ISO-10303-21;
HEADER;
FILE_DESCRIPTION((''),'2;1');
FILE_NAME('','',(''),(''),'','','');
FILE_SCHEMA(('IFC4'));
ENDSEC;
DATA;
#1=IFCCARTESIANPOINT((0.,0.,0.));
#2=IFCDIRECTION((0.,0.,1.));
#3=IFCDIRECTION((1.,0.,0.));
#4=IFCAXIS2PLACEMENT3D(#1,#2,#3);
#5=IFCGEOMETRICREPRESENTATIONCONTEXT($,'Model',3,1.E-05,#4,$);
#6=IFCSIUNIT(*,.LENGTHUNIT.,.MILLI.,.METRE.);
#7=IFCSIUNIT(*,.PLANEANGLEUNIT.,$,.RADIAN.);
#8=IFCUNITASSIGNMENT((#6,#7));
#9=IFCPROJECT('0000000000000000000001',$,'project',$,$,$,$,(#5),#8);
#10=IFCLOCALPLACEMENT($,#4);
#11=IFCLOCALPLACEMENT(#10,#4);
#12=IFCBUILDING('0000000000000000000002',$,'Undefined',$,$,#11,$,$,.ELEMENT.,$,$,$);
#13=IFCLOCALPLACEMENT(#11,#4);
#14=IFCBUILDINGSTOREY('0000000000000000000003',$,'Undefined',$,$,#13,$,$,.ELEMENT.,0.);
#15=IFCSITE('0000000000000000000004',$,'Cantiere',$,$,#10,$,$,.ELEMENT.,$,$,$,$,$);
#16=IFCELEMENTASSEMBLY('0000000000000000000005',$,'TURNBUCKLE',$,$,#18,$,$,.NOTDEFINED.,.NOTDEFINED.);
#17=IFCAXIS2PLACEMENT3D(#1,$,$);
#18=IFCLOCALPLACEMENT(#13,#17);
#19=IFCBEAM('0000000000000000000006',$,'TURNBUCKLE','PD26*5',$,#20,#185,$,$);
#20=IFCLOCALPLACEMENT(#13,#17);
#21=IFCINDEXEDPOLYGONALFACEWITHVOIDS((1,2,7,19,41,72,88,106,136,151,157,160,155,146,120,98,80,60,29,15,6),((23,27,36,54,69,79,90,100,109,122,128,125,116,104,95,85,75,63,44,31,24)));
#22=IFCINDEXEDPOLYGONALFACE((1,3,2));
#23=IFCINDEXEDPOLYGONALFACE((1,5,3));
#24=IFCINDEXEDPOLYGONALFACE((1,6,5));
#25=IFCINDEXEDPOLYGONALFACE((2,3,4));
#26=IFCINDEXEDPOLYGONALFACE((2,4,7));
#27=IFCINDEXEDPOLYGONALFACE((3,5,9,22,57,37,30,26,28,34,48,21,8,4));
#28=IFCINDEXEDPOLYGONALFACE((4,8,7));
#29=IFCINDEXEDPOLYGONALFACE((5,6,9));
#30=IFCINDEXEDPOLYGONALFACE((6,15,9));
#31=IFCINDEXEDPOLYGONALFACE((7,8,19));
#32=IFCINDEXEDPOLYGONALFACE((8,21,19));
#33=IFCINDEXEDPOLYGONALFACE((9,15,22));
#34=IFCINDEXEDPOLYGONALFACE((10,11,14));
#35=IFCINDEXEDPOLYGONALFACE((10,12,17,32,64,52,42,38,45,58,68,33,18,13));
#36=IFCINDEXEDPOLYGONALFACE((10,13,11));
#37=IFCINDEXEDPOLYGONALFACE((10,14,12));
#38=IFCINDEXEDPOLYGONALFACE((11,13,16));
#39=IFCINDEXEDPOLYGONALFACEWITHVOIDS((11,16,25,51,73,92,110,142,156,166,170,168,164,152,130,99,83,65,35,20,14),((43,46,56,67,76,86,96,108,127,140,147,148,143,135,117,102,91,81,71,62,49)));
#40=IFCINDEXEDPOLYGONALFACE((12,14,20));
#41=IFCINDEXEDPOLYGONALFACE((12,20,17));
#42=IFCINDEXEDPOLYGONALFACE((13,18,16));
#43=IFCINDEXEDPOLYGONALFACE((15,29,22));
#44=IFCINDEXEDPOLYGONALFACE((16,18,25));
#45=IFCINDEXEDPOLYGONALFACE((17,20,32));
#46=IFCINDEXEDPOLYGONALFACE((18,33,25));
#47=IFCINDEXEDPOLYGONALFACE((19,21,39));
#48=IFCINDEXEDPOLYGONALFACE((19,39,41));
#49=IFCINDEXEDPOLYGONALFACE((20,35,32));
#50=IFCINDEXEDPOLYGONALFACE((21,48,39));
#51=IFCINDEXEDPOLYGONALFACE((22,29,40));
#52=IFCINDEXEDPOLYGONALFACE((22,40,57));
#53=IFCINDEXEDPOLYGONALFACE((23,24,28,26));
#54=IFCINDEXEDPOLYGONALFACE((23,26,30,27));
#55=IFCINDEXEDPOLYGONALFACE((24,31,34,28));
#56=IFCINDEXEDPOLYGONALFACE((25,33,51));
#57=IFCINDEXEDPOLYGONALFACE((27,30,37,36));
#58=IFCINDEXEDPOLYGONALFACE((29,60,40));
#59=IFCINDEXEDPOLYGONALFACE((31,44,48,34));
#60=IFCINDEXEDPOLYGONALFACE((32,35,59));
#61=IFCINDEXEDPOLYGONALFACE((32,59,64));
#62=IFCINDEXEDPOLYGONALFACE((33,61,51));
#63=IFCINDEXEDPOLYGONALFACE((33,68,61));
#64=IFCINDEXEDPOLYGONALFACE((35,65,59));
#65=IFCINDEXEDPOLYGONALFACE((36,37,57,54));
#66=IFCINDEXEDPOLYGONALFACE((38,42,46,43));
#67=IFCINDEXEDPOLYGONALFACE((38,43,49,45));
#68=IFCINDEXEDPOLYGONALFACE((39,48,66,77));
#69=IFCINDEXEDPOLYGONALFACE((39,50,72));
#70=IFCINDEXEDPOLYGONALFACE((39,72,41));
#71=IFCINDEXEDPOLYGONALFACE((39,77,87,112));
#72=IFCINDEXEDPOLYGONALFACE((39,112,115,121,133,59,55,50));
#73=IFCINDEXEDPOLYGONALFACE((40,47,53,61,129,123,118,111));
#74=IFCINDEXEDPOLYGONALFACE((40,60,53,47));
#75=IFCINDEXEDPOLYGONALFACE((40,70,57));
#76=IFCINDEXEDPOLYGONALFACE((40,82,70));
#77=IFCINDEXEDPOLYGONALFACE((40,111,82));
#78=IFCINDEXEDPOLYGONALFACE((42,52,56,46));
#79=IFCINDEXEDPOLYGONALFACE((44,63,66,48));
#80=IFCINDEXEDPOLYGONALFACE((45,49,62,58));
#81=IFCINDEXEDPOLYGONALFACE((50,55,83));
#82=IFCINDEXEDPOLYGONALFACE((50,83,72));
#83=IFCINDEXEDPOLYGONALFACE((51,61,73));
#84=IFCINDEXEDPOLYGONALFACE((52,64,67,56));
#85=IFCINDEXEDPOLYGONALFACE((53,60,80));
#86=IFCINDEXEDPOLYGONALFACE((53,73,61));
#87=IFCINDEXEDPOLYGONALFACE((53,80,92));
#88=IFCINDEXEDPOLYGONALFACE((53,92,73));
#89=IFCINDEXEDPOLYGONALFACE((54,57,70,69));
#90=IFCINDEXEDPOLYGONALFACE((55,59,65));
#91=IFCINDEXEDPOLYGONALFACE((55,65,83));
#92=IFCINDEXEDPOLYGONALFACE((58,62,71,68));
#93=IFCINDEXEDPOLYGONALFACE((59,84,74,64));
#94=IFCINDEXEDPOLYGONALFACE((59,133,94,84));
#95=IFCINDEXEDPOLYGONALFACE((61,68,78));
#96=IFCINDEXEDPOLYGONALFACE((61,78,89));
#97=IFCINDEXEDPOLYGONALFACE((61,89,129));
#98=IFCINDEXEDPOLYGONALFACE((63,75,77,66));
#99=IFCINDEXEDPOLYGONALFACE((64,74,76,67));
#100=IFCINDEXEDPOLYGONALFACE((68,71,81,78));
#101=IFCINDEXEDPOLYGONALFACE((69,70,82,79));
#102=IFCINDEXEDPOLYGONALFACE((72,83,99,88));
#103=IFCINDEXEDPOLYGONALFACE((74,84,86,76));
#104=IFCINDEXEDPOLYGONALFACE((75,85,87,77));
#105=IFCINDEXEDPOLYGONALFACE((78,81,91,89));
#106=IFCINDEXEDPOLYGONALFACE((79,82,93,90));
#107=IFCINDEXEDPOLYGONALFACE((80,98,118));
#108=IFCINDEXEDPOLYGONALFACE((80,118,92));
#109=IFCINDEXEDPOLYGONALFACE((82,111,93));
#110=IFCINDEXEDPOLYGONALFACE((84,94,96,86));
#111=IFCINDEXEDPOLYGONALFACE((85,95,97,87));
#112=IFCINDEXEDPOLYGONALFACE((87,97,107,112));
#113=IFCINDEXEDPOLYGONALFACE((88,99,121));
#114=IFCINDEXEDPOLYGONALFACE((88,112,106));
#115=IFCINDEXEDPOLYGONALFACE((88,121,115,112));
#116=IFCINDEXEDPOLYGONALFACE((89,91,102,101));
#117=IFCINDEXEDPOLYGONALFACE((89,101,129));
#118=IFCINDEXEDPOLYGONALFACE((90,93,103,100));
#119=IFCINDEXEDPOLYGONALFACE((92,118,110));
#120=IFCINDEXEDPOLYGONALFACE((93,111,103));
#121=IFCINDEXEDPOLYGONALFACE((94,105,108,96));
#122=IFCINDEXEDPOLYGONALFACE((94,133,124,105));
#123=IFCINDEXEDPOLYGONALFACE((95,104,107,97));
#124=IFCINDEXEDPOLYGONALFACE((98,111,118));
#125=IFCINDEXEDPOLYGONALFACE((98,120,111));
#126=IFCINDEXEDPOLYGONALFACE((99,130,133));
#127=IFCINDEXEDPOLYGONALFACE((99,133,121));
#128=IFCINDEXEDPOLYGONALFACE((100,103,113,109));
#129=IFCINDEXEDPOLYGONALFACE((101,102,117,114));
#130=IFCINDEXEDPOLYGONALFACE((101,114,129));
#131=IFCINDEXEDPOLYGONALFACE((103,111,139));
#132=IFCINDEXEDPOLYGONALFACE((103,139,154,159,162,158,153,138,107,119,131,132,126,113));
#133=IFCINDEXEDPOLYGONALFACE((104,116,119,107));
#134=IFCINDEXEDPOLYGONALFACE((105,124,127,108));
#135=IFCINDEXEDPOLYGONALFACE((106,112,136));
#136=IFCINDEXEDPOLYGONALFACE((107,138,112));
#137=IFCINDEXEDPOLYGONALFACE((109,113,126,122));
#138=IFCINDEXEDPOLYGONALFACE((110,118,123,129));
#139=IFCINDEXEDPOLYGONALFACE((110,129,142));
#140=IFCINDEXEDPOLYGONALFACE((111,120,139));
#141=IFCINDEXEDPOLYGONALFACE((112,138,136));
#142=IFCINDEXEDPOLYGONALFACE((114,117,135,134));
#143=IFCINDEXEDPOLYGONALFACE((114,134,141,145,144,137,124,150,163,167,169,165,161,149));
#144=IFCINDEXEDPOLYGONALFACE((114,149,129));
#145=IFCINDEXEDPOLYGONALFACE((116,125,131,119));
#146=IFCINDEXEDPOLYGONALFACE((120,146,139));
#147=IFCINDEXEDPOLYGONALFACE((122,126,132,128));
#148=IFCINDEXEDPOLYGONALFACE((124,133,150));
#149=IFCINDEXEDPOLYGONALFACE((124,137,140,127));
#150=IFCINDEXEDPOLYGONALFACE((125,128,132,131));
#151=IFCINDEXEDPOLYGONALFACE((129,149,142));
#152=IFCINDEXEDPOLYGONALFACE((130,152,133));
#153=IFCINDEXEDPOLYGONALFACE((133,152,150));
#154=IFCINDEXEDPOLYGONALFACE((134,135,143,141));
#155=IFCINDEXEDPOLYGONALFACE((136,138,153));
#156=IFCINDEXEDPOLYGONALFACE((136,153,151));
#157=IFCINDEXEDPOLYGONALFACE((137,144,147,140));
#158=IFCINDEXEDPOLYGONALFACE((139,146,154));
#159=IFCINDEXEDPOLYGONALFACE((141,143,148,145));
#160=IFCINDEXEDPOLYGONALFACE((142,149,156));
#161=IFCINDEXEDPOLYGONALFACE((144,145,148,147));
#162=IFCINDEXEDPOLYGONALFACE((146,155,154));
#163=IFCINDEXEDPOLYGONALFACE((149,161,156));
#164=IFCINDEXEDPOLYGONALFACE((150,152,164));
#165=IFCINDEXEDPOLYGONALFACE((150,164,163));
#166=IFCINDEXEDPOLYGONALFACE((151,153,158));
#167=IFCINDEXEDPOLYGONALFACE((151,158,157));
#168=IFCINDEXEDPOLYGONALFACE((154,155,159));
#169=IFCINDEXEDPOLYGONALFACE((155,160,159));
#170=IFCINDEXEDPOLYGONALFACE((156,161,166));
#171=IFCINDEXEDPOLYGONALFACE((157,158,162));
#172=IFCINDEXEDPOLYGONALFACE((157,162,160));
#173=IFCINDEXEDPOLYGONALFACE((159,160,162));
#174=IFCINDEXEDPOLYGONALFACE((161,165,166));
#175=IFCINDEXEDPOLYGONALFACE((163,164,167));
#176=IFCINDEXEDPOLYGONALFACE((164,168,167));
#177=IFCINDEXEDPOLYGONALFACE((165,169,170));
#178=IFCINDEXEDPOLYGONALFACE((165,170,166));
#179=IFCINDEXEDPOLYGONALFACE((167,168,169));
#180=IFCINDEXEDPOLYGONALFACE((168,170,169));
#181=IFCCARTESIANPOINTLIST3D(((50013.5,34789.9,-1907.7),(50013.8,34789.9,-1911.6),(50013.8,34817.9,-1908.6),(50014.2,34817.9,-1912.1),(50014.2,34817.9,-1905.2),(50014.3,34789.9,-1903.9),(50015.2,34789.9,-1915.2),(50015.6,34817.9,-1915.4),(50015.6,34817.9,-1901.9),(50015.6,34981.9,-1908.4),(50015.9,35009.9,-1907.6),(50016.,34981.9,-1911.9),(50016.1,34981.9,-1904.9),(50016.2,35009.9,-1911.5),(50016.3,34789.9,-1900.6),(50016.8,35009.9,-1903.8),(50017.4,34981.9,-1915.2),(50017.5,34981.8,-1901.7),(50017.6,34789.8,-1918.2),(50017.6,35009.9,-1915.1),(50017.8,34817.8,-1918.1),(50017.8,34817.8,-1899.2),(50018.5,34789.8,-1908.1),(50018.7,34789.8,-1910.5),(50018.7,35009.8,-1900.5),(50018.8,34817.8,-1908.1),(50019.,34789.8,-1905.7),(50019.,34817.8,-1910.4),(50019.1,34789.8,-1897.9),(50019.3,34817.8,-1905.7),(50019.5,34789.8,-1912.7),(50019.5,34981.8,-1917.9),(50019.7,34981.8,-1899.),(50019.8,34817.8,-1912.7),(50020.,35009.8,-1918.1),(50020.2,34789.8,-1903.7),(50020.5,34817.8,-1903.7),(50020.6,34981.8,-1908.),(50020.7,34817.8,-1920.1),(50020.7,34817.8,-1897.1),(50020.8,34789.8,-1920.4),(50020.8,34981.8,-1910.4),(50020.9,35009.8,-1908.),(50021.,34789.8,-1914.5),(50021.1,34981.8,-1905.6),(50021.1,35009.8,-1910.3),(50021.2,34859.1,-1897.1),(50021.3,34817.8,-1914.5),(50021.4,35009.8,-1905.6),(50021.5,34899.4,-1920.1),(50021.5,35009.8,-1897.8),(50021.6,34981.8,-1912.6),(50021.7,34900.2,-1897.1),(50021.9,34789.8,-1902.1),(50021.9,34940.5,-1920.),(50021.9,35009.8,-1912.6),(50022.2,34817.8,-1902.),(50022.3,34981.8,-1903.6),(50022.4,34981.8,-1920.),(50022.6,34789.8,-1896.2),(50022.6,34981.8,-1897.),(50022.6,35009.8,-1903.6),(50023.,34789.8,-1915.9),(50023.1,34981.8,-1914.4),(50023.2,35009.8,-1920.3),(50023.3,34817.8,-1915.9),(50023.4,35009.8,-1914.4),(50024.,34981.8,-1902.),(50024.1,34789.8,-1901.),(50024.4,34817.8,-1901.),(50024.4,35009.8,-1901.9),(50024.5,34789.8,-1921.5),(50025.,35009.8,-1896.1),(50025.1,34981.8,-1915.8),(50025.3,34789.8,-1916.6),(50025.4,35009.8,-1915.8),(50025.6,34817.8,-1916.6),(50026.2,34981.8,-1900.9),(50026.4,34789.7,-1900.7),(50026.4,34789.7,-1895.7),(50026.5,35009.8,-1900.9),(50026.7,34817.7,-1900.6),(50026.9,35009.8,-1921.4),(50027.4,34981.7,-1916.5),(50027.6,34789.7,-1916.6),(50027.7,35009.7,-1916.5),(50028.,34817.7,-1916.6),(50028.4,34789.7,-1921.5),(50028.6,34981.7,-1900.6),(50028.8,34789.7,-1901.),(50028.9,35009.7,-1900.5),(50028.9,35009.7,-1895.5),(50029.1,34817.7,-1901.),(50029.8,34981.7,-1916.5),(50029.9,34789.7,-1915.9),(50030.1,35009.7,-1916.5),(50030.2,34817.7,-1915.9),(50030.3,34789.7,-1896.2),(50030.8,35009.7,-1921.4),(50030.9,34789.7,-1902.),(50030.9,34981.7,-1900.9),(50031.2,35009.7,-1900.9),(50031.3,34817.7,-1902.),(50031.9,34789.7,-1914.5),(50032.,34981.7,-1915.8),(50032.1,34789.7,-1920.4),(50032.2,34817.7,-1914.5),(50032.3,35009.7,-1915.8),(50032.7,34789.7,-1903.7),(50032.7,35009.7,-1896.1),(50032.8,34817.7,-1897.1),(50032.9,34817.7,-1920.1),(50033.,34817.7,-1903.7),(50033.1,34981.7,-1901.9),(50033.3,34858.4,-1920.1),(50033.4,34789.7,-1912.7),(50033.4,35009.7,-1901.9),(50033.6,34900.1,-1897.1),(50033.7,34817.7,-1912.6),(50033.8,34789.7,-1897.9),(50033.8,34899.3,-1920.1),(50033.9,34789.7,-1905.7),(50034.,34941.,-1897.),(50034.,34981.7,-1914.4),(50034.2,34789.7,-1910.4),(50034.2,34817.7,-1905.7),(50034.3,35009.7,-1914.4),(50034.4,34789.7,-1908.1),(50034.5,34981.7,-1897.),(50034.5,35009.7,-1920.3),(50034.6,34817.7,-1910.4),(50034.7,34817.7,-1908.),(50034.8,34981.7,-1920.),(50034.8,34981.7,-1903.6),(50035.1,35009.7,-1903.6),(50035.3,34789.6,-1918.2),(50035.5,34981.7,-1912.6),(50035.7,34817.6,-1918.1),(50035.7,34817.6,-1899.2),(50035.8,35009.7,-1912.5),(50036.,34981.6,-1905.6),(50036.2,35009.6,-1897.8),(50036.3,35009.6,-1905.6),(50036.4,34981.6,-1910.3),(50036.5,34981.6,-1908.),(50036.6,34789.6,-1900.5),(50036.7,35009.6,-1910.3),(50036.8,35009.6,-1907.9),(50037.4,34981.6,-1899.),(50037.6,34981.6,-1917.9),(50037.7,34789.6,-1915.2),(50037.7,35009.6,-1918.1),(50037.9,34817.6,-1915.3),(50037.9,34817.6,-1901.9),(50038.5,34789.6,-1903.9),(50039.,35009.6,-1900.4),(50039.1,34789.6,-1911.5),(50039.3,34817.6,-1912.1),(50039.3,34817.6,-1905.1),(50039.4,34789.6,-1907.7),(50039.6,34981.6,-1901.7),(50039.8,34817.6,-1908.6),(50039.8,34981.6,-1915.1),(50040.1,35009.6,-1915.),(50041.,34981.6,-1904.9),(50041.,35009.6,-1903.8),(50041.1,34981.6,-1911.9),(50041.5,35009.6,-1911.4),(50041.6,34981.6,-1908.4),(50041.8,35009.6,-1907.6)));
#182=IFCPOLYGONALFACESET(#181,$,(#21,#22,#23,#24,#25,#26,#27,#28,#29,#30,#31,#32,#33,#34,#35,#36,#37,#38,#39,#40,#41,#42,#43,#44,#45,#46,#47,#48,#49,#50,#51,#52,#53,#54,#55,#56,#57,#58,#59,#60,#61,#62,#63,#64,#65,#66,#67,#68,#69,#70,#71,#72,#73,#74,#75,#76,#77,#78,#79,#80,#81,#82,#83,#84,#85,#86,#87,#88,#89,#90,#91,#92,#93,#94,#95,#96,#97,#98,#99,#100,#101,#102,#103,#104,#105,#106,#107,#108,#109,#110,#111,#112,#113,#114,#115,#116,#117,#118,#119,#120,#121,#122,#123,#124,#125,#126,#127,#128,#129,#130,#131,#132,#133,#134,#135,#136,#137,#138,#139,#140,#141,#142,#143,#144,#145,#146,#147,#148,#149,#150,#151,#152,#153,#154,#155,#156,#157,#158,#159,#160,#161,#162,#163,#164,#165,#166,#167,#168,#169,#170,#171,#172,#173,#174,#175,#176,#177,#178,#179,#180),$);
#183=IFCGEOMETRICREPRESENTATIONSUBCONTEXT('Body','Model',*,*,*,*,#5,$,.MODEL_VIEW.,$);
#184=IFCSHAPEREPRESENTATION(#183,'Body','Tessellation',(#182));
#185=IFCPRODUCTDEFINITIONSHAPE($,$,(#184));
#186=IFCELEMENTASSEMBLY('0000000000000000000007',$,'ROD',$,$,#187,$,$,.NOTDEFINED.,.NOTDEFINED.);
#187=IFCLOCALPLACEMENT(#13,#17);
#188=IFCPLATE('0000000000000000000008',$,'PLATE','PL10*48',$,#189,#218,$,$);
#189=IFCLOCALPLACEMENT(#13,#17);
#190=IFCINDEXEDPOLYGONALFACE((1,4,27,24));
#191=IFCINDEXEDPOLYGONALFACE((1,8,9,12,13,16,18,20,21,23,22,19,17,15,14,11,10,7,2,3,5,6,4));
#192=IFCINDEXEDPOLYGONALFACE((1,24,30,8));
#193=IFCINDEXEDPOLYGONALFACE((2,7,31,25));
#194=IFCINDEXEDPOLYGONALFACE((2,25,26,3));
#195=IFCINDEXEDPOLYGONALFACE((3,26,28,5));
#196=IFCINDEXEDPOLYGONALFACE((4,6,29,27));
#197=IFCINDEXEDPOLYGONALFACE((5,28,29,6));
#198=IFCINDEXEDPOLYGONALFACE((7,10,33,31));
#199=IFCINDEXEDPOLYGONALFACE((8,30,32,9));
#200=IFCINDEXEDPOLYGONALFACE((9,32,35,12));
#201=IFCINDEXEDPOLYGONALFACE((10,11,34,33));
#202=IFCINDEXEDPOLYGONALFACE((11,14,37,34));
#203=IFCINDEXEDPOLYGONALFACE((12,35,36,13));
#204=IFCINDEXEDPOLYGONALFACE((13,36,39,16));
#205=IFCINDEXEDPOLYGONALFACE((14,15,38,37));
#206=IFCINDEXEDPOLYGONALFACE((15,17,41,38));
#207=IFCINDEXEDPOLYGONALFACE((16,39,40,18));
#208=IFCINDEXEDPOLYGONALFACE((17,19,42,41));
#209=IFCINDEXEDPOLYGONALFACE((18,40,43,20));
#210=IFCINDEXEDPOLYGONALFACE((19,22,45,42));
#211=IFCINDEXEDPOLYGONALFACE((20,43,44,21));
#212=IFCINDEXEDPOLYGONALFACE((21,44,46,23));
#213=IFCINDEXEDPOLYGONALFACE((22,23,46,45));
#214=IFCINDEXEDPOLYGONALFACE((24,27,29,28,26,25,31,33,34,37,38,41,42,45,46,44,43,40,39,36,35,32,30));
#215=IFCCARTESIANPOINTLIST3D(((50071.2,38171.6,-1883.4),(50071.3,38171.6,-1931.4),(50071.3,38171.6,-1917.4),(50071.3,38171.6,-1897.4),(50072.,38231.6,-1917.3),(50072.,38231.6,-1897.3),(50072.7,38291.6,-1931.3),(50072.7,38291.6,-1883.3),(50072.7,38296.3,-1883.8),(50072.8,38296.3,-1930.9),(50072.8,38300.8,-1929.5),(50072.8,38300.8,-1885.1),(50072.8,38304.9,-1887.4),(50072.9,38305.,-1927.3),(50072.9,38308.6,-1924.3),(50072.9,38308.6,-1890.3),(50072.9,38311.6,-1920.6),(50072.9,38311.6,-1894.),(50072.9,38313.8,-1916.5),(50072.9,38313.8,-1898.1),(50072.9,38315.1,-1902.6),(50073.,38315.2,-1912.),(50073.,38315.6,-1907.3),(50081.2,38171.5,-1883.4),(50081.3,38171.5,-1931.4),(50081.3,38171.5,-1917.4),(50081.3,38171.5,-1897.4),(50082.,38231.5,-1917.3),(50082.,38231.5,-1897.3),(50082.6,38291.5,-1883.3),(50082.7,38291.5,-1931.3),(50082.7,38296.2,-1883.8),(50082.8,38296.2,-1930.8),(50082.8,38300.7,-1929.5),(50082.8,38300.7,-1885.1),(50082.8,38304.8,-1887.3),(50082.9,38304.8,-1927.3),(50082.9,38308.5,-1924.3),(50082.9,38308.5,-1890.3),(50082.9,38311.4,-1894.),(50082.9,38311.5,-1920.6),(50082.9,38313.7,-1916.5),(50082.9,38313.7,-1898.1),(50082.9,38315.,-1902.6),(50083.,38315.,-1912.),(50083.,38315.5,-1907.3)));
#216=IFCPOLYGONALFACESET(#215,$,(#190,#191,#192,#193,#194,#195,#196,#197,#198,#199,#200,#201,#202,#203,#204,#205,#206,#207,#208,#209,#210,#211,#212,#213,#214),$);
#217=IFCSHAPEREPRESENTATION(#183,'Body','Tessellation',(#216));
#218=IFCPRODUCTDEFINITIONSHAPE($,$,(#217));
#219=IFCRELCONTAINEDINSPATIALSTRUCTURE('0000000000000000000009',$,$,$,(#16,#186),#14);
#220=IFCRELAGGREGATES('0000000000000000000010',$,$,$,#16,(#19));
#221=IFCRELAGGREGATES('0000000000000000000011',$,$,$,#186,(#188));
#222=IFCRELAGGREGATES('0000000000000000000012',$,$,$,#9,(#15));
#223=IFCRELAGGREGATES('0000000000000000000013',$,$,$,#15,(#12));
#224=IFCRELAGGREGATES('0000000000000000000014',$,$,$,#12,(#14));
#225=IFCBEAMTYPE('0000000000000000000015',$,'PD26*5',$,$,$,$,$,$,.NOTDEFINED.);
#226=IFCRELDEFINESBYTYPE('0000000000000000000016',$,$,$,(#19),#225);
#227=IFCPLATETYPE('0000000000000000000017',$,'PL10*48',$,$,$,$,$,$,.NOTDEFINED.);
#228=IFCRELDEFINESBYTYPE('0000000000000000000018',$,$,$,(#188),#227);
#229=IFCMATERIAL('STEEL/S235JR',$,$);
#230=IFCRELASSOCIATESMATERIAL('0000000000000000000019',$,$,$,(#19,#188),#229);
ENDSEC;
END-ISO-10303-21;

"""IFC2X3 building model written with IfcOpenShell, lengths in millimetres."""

from ifc_helpers import new_model, si_unit, frame, origin_with_axes, origin_2d_with_axis, place, context, subcontext, project, spatial, polyline, rectangle, hollow_circle, outline, extrude, boolean, material, type_object, element, aggregate, save


model = new_model("IFC2X3")

# Units and contexts
model_context = context("Model", 3, precision=1e-05, world=origin_with_axes())
body_context = subcontext(model_context, "Body", "Model", "MODEL_VIEW")
ifc_project = project(units=[si_unit("LENGTHUNIT", "METRE", prefix="MILLI"), si_unit("PLANEANGLEUNIT", "RADIAN")], contexts=[model_context])

# Site, building, storey
site_placement = place(None, origin_with_axes())
site = spatial("IfcSite", under=ifc_project, at=site_placement, Name="Cantiere", CompositionType="ELEMENT")
building_placement = place(site_placement, origin_with_axes())
building = spatial("IfcBuilding", under=site, at=building_placement, Name="Undefined", CompositionType="ELEMENT")
storey_placement = place(building_placement, origin_with_axes())
storey = spatial("IfcBuildingStorey", under=building, at=storey_placement, Name="Undefined", CompositionType="ELEMENT", Elevation=0.0)

# Element assembly, beam
assembly_1_placement = place(storey_placement, origin_with_axes())
assembly_1 = element("IfcElementAssembly", 1, at=assembly_1_placement, inside=storey, Name="TURNBUCKLE", AssemblyPlace="NOTDEFINED", PredefinedType="NOTDEFINED")
ifc_material_1 = material(Name="STEEL/S235JR")
beam_type = type_object("IfcBeamType", Name="PD26*5", PredefinedType="NOTDEFINED")
beam_placement = place(assembly_1_placement, frame((50026.4, 34789.7, -1908.7), z_axis=(-0.999939, 0.011003, -0.001062), x_axis=(0.011002, 0.999939, 0.000515)))
beam = element("IfcBeam", 2, at=beam_placement, type_object=beam_type, material=ifc_material_1, Name="TURNBUCKLE", Description="PD26*5", context=body_context, shape_type="CSG", body=[
    boolean("DIFFERENCE", extrude(hollow_circle(Radius=13.0, WallThickness=5.0, at=origin_2d_with_axis()), frame((220.0, 0.0, 0.0), z_axis=(-1.0, 0.0, 0.0), x_axis=(0.0, -1.0, 0.0)), (0.0, 0.0, 1.0), 220.0), extrude(rectangle(XDim=23.0, YDim=68.0, at=origin_2d_with_axis()), frame((28.0, 0.0, 0.0), z_axis=(1.0, -0.000389, 0.0), x_axis=(0.000389, 1.0, 0.0)), (0.0, 0.0, 1.0), 164.0)),
])
aggregate(assembly_1, [beam])

# Element assembly, plate
assembly_2_placement = place(storey_placement, origin_with_axes())
assembly_2 = element("IfcElementAssembly", 3, at=assembly_2_placement, inside=storey, Name="ROD", AssemblyPlace="NOTDEFINED", PredefinedType="NOTDEFINED")
plate_type_1 = type_object("IfcPlateType", Name="PL10*48", PredefinedType="NOTDEFINED")
plate_1_placement = place(assembly_2_placement, frame((50076.3, 38171.6, -1931.4), z_axis=(0.999931, -0.011737, 0.001062), x_axis=(0.011737, 0.999931, 0.000382)))
plate_1 = element("IfcPlate", 4, at=plate_1_placement, type_object=plate_type_1, material=ifc_material_1, Name="PLATE", Description="PL10*48", context=body_context, shape_type="SweptSolid", body=[
    extrude(outline(polyline([(0.0, 0.0), (120.0, 0.0), (124.7, 0.5), (129.2, 1.8), (133.3, 4.0), (137.0, 7.0), (140.0, 10.7), (142.2, 14.8), (143.5, 19.3), (144.0, 24.0), (144.0, 24.0), (143.5, 28.7), (142.2, 33.2), (140.0, 37.3), (137.0, 41.0), (133.3, 44.0), (129.2, 46.2), (124.7, 47.5), (120.0, 48.0), (0.0, 48.0), (0.0, 34.0), (60.0, 34.0), (60.0, 14.0), (0.0, 14.0), (0.0, 0.0)])), frame((0.0, 0.0, -5.0), z_axis=(0.0, 0.0, 1.0), x_axis=(1.0, 0.0, 0.0)), (0.0, 0.0, 1.0), 10.0),
])
aggregate(assembly_2, [plate_1])

save(model, "model.ifc")
